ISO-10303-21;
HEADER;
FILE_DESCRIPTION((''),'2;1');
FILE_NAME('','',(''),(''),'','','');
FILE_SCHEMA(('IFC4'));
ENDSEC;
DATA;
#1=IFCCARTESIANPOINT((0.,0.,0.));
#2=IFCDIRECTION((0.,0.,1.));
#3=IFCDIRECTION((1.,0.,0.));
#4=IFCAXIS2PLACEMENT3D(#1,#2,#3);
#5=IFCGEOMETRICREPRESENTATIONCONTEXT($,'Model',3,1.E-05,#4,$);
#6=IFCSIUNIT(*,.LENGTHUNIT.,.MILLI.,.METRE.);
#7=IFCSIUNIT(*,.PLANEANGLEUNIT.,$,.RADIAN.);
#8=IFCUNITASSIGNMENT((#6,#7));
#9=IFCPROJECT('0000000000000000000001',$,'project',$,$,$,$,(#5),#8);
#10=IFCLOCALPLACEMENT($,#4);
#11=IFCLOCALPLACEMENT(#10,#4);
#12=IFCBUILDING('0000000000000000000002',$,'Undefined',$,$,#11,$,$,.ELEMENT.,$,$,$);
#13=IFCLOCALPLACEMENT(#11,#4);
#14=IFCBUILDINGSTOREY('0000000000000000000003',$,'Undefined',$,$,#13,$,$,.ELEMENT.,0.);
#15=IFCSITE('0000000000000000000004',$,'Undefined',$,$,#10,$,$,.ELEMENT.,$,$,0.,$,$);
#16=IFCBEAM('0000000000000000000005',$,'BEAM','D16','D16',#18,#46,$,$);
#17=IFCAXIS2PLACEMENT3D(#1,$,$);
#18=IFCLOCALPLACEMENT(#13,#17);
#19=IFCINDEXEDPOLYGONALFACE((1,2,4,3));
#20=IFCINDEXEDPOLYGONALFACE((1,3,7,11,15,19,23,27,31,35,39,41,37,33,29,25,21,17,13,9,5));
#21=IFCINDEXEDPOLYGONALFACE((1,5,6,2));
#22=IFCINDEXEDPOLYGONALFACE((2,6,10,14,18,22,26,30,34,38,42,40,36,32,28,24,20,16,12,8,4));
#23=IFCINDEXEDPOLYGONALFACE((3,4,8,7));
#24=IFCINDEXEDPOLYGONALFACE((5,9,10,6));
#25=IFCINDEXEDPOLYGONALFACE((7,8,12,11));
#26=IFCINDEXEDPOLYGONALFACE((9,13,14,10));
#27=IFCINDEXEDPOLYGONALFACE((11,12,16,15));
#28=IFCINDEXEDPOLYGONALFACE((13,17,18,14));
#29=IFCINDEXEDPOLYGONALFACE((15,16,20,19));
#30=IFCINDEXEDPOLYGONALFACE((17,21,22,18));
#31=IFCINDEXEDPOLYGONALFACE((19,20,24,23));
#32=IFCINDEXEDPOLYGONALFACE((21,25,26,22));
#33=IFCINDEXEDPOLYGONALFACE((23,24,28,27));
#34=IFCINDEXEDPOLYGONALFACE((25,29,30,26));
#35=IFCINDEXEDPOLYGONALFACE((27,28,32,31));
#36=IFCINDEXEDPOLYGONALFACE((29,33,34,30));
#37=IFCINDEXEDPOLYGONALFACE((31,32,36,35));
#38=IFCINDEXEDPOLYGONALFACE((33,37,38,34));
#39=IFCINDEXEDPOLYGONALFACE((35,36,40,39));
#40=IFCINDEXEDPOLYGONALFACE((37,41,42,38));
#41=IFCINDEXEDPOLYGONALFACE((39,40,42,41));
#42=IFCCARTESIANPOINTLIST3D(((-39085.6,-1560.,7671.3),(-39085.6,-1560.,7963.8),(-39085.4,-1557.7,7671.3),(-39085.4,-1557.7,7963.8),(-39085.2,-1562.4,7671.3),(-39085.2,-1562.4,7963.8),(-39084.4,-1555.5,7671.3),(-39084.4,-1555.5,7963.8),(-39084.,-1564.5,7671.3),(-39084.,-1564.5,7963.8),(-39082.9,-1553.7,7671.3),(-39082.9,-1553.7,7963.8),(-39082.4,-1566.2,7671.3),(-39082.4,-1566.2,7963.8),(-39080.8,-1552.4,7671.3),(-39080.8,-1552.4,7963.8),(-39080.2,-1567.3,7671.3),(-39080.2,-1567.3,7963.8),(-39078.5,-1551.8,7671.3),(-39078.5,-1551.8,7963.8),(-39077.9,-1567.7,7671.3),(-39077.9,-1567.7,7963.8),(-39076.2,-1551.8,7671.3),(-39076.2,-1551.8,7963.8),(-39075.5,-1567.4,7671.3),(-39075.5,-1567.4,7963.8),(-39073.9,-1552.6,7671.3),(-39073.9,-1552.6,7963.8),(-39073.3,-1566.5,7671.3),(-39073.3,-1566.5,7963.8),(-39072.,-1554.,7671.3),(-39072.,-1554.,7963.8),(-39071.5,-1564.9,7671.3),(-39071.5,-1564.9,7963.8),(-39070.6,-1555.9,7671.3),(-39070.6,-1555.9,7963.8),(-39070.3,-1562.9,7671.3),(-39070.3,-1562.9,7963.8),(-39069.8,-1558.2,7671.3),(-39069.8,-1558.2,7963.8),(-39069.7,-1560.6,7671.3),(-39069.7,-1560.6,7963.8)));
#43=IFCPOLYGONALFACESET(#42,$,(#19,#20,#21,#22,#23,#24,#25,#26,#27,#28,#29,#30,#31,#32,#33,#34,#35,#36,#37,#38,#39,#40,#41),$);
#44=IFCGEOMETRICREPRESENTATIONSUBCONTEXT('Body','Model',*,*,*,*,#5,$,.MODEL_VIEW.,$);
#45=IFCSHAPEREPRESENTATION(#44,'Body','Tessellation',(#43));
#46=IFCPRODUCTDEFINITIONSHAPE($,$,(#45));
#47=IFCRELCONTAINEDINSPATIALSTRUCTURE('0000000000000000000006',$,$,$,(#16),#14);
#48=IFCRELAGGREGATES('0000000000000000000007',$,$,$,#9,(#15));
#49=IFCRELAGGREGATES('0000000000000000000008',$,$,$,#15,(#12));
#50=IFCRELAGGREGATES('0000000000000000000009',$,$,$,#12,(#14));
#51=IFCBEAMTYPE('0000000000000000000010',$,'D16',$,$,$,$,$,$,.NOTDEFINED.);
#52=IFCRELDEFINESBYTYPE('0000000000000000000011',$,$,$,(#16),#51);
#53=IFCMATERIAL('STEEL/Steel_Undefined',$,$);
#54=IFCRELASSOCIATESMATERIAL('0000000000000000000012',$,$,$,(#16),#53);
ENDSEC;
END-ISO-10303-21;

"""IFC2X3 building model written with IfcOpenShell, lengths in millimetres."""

from ifc_helpers import new_model, si_unit, frame, origin_with_axes, origin_2d_with_axis, place, context, subcontext, project, spatial, circle, extrude, material, type_object, element, save


model = new_model("IFC2X3")

# Units and contexts
model_context = context("Model", 3, precision=1e-05, world=origin_with_axes())
body_context = subcontext(model_context, "Body", "Model", "MODEL_VIEW")
ifc_project = project(units=[si_unit("LENGTHUNIT", "METRE", prefix="MILLI"), si_unit("PLANEANGLEUNIT", "RADIAN")], contexts=[model_context])

# Site, building, storey
site_placement = place(None, origin_with_axes())
site = spatial("IfcSite", under=ifc_project, at=site_placement, Name="Undefined", CompositionType="ELEMENT", RefElevation=0.0)
building_placement = place(site_placement, origin_with_axes())
building = spatial("IfcBuilding", under=site, at=building_placement, Name="Undefined", CompositionType="ELEMENT")
storey_placement = place(building_placement, origin_with_axes())
storey = spatial("IfcBuildingStorey", under=building, at=storey_placement, Name="Undefined", CompositionType="ELEMENT", Elevation=0.0)

# Shared definitions
ifc_material = material(Name="STEEL/Steel_Undefined")

# Beam
beam_type_1 = type_object("IfcBeamType", Name="D16", PredefinedType="NOTDEFINED")
beam_1_placement = place(storey_placement, frame((-39077.6, -1559.7, 7963.8), z_axis=(-0.915553, -0.402198, 0.0), x_axis=(0.0, 0.0, -1.0)))
element("IfcBeam", 1, at=beam_1_placement, inside=storey, type_object=beam_type_1, material=ifc_material, Name="BEAM", Description="D16", ObjectType="D16", context=body_context, shape_type="SweptSolid", body=[
    extrude(circle(Radius=8.0, at=origin_2d_with_axis()), frame((292.6, 0.0, 0.0), z_axis=(-1.0, 0.0, 0.0), x_axis=(0.0, -1.0, 0.0)), (0.0, 0.0, 1.0), 292.6),
])

save(model, "model.ifc")
